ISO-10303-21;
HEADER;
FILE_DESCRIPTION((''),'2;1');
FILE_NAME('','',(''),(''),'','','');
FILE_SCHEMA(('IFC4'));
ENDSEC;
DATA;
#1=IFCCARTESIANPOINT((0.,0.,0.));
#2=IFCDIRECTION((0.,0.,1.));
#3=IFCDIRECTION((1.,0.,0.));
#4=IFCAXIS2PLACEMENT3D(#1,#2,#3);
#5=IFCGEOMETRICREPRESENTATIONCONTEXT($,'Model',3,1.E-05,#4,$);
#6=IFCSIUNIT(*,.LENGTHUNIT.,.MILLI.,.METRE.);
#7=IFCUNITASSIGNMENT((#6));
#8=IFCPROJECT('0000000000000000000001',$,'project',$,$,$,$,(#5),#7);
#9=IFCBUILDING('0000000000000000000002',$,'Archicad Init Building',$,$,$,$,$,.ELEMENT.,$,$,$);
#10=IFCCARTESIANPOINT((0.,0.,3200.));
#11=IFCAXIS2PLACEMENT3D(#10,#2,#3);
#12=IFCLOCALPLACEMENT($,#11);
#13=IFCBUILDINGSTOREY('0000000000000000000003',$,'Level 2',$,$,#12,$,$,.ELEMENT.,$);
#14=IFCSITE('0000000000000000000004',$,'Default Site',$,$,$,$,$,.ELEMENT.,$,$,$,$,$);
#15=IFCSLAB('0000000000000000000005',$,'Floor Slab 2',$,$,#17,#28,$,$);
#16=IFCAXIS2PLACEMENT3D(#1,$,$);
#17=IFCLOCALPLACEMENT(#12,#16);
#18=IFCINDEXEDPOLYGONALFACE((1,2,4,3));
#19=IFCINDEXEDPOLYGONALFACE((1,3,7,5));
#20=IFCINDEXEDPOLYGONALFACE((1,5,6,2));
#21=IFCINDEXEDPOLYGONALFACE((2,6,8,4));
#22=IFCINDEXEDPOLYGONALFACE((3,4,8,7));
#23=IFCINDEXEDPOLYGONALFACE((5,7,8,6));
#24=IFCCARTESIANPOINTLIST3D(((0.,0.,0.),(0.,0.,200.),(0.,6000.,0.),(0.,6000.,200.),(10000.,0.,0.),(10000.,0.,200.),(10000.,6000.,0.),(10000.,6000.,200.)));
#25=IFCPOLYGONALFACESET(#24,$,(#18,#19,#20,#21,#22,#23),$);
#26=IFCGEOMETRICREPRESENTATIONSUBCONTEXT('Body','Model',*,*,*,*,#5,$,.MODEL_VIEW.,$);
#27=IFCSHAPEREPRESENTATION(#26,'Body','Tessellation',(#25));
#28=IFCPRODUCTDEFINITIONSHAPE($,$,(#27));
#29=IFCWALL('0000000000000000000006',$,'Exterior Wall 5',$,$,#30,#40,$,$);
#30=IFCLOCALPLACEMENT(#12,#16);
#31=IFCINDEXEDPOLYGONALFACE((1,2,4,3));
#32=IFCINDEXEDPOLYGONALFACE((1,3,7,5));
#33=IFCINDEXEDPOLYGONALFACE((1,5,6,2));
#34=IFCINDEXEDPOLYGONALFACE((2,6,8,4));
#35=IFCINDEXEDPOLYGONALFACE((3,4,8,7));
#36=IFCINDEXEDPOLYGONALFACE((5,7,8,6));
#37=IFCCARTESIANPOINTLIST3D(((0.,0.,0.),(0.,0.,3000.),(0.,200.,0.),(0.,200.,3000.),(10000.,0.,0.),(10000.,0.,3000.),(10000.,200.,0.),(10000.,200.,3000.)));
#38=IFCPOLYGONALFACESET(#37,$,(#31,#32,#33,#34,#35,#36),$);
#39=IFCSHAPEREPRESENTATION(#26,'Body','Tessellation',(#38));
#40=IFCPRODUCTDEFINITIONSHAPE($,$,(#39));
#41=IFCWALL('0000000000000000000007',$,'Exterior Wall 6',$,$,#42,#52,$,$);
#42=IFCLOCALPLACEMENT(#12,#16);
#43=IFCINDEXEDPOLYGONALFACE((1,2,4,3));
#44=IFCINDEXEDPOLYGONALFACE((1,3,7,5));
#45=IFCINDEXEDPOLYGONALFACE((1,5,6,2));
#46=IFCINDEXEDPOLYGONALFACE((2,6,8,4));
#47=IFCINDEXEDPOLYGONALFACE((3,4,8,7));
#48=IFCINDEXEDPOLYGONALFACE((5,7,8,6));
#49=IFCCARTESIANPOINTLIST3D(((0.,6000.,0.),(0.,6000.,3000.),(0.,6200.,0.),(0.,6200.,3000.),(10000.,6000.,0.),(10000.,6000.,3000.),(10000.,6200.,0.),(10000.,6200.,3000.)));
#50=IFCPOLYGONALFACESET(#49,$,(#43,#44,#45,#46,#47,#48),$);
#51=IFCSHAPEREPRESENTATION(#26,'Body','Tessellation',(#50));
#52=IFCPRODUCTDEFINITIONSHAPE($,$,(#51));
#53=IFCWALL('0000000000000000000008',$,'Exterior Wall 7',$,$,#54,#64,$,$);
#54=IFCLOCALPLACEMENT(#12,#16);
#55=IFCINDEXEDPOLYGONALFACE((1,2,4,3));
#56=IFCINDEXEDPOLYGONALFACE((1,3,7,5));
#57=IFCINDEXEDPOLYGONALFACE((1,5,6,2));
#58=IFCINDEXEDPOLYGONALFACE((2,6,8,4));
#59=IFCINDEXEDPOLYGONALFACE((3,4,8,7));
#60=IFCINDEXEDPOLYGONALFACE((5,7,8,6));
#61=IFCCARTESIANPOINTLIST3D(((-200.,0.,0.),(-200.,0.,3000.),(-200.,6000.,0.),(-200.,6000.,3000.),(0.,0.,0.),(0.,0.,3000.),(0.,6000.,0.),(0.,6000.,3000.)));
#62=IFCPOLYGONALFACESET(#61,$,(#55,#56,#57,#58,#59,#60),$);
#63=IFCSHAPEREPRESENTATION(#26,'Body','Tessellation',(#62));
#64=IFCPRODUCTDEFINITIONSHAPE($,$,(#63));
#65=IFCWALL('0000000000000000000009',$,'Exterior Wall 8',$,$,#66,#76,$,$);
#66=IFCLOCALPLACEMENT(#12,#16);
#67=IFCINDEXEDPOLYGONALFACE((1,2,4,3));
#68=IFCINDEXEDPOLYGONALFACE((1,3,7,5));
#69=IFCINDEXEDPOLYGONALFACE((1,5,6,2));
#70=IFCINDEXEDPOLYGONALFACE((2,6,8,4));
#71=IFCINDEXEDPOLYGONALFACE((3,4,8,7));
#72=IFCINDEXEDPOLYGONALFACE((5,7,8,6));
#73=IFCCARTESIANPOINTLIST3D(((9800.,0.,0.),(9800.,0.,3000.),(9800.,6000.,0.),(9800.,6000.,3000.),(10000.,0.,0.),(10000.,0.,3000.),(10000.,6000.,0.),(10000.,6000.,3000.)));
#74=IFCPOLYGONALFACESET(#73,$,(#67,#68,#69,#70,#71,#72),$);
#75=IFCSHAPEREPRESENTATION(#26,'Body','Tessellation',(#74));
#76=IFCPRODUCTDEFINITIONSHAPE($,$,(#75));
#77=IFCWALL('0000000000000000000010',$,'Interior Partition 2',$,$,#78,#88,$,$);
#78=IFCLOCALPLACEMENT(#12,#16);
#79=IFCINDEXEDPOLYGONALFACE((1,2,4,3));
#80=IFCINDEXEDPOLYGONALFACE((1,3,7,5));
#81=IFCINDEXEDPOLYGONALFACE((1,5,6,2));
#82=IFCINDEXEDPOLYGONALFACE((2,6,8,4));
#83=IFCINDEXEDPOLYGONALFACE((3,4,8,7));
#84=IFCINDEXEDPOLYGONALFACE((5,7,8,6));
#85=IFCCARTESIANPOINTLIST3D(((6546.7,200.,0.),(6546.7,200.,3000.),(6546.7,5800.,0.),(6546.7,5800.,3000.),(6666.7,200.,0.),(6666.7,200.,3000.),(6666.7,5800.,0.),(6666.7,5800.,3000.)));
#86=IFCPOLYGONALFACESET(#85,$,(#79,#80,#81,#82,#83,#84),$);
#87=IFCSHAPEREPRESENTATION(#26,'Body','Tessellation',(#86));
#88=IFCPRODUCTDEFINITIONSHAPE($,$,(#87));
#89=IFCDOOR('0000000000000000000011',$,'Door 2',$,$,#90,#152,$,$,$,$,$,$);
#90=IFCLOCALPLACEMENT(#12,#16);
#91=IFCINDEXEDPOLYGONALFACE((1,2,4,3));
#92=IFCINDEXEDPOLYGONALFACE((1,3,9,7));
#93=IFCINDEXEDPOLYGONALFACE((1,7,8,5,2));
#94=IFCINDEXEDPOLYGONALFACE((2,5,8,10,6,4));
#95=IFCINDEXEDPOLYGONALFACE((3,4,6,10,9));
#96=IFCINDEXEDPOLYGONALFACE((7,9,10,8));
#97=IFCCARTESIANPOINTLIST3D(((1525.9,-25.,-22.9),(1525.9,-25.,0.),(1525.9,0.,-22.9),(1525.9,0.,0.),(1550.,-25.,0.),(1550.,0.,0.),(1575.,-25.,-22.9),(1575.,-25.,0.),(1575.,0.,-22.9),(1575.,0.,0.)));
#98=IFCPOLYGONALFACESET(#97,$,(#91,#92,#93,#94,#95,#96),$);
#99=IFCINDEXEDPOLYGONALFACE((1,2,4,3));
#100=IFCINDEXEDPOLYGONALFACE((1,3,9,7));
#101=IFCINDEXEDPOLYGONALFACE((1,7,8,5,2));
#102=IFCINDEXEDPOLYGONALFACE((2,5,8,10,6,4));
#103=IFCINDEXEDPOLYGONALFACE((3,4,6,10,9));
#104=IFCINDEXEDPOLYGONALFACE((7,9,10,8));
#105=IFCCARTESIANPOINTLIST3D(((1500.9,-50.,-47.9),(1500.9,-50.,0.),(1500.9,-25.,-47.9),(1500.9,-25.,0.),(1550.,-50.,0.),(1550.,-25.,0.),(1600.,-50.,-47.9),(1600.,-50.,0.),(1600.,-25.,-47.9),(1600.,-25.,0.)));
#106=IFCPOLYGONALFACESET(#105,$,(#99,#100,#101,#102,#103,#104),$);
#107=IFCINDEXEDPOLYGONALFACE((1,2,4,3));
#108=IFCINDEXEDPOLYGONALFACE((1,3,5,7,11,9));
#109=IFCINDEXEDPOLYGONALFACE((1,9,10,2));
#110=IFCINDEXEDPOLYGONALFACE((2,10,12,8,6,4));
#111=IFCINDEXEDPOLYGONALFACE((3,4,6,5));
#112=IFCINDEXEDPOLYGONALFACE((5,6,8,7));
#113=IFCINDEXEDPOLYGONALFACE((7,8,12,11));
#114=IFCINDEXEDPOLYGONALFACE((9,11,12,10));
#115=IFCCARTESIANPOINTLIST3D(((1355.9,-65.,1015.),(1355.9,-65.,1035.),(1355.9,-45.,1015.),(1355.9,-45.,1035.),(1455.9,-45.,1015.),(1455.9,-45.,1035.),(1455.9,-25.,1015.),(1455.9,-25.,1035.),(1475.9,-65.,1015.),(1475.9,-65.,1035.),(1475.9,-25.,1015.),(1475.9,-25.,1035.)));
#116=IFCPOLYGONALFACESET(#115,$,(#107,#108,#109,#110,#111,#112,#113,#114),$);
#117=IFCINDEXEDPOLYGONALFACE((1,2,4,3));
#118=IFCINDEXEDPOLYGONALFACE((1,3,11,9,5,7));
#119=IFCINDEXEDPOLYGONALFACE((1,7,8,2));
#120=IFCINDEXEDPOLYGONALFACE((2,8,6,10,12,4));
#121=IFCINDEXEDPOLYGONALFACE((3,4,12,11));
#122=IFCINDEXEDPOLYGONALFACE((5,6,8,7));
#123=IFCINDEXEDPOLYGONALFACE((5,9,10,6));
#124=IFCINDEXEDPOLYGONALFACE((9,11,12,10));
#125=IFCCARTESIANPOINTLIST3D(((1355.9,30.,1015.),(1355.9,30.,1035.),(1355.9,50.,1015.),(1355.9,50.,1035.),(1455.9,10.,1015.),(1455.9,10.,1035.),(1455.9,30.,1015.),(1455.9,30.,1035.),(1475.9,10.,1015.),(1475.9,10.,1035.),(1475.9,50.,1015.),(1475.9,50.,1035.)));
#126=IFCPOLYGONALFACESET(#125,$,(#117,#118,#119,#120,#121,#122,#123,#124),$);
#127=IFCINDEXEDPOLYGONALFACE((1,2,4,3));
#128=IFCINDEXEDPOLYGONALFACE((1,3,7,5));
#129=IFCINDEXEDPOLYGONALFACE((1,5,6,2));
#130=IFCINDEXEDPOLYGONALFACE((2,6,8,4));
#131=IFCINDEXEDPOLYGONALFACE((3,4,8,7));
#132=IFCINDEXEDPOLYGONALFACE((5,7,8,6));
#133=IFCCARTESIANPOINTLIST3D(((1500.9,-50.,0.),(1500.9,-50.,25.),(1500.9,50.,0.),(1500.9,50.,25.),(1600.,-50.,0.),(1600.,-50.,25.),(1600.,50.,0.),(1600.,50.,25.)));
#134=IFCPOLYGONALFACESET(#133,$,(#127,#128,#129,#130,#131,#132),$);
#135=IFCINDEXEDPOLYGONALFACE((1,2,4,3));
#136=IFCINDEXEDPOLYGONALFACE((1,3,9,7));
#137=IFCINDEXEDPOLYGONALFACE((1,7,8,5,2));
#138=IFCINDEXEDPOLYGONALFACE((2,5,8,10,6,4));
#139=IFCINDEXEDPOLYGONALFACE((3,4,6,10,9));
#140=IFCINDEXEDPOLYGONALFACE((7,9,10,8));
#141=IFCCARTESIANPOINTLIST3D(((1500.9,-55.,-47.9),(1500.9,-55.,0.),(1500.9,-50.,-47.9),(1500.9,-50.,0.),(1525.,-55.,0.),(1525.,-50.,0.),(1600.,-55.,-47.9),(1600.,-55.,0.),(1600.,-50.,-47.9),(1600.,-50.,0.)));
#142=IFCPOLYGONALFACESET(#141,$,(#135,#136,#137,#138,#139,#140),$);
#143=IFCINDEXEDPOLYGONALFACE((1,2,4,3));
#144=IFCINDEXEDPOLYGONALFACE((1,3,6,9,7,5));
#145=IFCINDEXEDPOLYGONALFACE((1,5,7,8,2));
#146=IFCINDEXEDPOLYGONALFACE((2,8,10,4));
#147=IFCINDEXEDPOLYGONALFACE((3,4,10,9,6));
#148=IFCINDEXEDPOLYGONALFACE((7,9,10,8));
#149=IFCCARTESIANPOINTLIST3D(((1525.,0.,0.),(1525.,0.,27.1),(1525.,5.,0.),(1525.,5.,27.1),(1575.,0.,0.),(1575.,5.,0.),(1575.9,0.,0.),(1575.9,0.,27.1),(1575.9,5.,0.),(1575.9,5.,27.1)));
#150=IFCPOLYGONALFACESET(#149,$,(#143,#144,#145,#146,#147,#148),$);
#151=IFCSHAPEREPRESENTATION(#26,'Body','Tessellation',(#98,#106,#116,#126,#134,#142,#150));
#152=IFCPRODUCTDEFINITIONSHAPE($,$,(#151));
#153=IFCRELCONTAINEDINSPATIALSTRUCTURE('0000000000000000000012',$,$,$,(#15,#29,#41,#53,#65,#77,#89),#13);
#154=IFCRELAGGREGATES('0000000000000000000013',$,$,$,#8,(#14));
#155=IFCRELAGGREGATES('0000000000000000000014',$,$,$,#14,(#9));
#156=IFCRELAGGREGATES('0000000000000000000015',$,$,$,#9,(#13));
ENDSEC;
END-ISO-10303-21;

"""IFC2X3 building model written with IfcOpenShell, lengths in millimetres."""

from ifc_helpers import new_model, si_unit, frame, origin_with_axes, place, context, subcontext, project, spatial, polyline, outline, extrude, element, save


model = new_model("IFC2X3")

# Units and contexts
model_context = context("Model", 3, precision=1e-05, world=origin_with_axes())
body_context = subcontext(model_context, "Body", "Model", "MODEL_VIEW")
ifc_project = project(units=[si_unit("LENGTHUNIT", "METRE", prefix="MILLI")], contexts=[model_context])

# Site, building, storey
site = spatial("IfcSite", under=ifc_project, Name="Default Site", CompositionType="ELEMENT")
building = spatial("IfcBuilding", under=site, Name="Archicad Init Building", CompositionType="ELEMENT")
storey_placement = place(None, frame((0.0, 0.0, 3200.0), z_axis=(0.0, 0.0, 1.0), x_axis=(1.0, 0.0, 0.0)))
storey = spatial("IfcBuildingStorey", under=building, at=storey_placement, Name="Level 2", CompositionType="ELEMENT")

# Slab
slab_placement = place(storey_placement, origin_with_axes())
element("IfcSlab", 1, at=slab_placement, inside=storey, Name="Floor Slab 2", context=body_context, shape_type="SweptSolid", body=[
    extrude(outline(polyline([(0.0, 0.0), (10000.0, 0.0), (10000.0, 6000.0), (0.0, 6000.0), (0.0, 0.0)])), origin_with_axes(), (0.0, 0.0, 1.0), 200.0),
])

# Walls
for number, where, z_axis, x_axis, name in (
    (2, (0.0, 0.0, 0.0), (0.0, 0.0, 1.0), (1.0, 0.0, 0.0), "Exterior Wall 5"),
    (3, (0.0, 6000.0, 0.0), (0.0, 0.0, 1.0), (1.0, 0.0, 0.0), "Exterior Wall 6"),
):
    element("IfcWall", number, at=place(storey_placement, frame(where, z_axis=z_axis, x_axis=x_axis)), inside=storey, Name=name, context=body_context, shape_type="SweptSolid", body=[
        extrude(outline(polyline([(0.0, 0.0), (0.0, 200.0), (10000.0, 200.0), (10000.0, 0.0), (0.0, 0.0)])), origin_with_axes(), (0.0, 0.0, 1.0), 3000.0),
    ])
for number, where, z_axis, x_axis, name in (
    (4, (0.0, 0.0, 0.0), (0.0, 0.0, 1.0), (0.0, 1.0, 0.0), "Exterior Wall 7"),
    (5, (10000.0, 0.0, 0.0), (0.0, 0.0, 1.0), (0.0, 1.0, 0.0), "Exterior Wall 8"),
):
    element("IfcWall", number, at=place(storey_placement, frame(where, z_axis=z_axis, x_axis=x_axis)), inside=storey, Name=name, context=body_context, shape_type="SweptSolid", body=[
        extrude(outline(polyline([(0.0, 0.0), (0.0, 200.0), (6000.0, 200.0), (6000.0, 0.0), (0.0, 0.0)])), origin_with_axes(), (0.0, 0.0, 1.0), 3000.0),
    ])
wall_placement = place(storey_placement, frame((6666.7, 200.0, 0.0), z_axis=(0.0, 0.0, 1.0), x_axis=(0.0, 1.0, 0.0)))
element("IfcWall", 6, at=wall_placement, inside=storey, Name="Interior Partition 2", context=body_context, shape_type="SweptSolid", body=[
    extrude(outline(polyline([(0.0, 0.0), (0.0, 120.0), (5600.0, 120.0), (5600.0, 0.0), (0.0, 0.0)])), origin_with_axes(), (0.0, 0.0, 1.0), 3000.0),
])

# Door
door_1_placement = place(storey_placement, frame((1550.0, -50.0, 0.0), z_axis=(0.0, 0.0, 1.0), x_axis=(1.0, 0.0, 0.0)))
element("IfcDoor", 7, at=door_1_placement, inside=storey, Name="Door 2", context=body_context, shape_type="SweptSolid", body=[
    extrude(outline(polyline([(0.0, 0.0), (0.0, 2.1), (0.9, 2.1), (0.9, 0.0), (-24.1, 0.0), (-24.1, -22.9), (25.0, -22.9), (25.0, 0.0), (0.0, 0.0)])), frame((0.0, 25.0, 0.0), z_axis=(0.0, -1.0, 0.0), x_axis=(1.0, 0.0, 0.0)), (0.0, 0.0, -1.0), 25.0),
    extrude(outline(polyline([(0.0, 0.0), (0.0, 2.1), (0.9, 2.1), (0.9, 0.0), (-49.1, 0.0), (-49.1, -47.9), (50.0, -47.9), (50.0, 0.0), (0.0, 0.0)])), frame((0.0, 0.0, 0.0), z_axis=(0.0, -1.0, 0.0), x_axis=(1.0, 0.0, 0.0)), (0.0, 0.0, -1.0), 25.0),
    extrude(outline(polyline([(0.0, 0.0), (-49.1, 0.0), (-49.1, 35.0), (0.0, 35.0), (0.0, 0.0)])), frame((25.0, 25.0, 25.0), z_axis=(0.0, 0.0, 1.0), x_axis=(1.0, 0.0, 0.0)), (0.0, 0.0, 1.0), -47.9),
    extrude(outline(polyline([(0.0, 0.0), (0.0, -40.0), (-120.0, -40.0), (-120.0, -20.0), (-20.0, -20.0), (-20.0, 0.0), (0.0, 0.0)])), frame((-74.1, 25.0, 1015.0), z_axis=(0.0, 0.0, 1.0), x_axis=(1.0, 0.0, 0.0)), (0.0, 0.0, 1.0), 20.0),
    extrude(outline(polyline([(0.0, 0.0), (0.0, 40.0), (-120.0, 40.0), (-120.0, 20.0), (-20.0, 20.0), (-20.0, 0.0), (0.0, 0.0)])), frame((-74.1, 60.0, 1015.0), z_axis=(0.0, 0.0, 1.0), x_axis=(1.0, 0.0, 0.0)), (0.0, 0.0, 1.0), 20.0),
    extrude(outline(polyline([(0.0, 0.0), (-99.1, 0.0), (-99.1, 100.0), (0.0, 100.0), (0.0, 0.0)])), frame((50.0, 0.0, 0.0), z_axis=(0.0, 0.0, 1.0), x_axis=(1.0, 0.0, 0.0)), (0.0, 0.0, 1.0), 25.0),
    extrude(outline(polyline([(0.0, 0.0), (0.0, 27.1), (50.9, 27.1), (50.9, 0.0), (-24.1, 0.0), (-24.1, -47.9), (75.0, -47.9), (75.0, 0.0), (0.0, 0.0)])), frame((-25.0, -5.0, 0.0), z_axis=(0.0, -1.0, 0.0), x_axis=(1.0, 0.0, 0.0)), (0.0, 0.0, -1.0), 5.0),
    extrude(outline(polyline([(0.0, 0.0), (0.0, 27.1), (50.9, 27.1), (50.9, 0.0), (0.9, 0.0), (0.9, -22.9), (50.0, -22.9), (50.0, 0.0), (0.0, 0.0)])), frame((-25.0, 50.0, 0.0), z_axis=(0.0, -1.0, 0.0), x_axis=(1.0, 0.0, 0.0)), (0.0, 0.0, -1.0), 5.0),
])

save(model, "model.ifc")
